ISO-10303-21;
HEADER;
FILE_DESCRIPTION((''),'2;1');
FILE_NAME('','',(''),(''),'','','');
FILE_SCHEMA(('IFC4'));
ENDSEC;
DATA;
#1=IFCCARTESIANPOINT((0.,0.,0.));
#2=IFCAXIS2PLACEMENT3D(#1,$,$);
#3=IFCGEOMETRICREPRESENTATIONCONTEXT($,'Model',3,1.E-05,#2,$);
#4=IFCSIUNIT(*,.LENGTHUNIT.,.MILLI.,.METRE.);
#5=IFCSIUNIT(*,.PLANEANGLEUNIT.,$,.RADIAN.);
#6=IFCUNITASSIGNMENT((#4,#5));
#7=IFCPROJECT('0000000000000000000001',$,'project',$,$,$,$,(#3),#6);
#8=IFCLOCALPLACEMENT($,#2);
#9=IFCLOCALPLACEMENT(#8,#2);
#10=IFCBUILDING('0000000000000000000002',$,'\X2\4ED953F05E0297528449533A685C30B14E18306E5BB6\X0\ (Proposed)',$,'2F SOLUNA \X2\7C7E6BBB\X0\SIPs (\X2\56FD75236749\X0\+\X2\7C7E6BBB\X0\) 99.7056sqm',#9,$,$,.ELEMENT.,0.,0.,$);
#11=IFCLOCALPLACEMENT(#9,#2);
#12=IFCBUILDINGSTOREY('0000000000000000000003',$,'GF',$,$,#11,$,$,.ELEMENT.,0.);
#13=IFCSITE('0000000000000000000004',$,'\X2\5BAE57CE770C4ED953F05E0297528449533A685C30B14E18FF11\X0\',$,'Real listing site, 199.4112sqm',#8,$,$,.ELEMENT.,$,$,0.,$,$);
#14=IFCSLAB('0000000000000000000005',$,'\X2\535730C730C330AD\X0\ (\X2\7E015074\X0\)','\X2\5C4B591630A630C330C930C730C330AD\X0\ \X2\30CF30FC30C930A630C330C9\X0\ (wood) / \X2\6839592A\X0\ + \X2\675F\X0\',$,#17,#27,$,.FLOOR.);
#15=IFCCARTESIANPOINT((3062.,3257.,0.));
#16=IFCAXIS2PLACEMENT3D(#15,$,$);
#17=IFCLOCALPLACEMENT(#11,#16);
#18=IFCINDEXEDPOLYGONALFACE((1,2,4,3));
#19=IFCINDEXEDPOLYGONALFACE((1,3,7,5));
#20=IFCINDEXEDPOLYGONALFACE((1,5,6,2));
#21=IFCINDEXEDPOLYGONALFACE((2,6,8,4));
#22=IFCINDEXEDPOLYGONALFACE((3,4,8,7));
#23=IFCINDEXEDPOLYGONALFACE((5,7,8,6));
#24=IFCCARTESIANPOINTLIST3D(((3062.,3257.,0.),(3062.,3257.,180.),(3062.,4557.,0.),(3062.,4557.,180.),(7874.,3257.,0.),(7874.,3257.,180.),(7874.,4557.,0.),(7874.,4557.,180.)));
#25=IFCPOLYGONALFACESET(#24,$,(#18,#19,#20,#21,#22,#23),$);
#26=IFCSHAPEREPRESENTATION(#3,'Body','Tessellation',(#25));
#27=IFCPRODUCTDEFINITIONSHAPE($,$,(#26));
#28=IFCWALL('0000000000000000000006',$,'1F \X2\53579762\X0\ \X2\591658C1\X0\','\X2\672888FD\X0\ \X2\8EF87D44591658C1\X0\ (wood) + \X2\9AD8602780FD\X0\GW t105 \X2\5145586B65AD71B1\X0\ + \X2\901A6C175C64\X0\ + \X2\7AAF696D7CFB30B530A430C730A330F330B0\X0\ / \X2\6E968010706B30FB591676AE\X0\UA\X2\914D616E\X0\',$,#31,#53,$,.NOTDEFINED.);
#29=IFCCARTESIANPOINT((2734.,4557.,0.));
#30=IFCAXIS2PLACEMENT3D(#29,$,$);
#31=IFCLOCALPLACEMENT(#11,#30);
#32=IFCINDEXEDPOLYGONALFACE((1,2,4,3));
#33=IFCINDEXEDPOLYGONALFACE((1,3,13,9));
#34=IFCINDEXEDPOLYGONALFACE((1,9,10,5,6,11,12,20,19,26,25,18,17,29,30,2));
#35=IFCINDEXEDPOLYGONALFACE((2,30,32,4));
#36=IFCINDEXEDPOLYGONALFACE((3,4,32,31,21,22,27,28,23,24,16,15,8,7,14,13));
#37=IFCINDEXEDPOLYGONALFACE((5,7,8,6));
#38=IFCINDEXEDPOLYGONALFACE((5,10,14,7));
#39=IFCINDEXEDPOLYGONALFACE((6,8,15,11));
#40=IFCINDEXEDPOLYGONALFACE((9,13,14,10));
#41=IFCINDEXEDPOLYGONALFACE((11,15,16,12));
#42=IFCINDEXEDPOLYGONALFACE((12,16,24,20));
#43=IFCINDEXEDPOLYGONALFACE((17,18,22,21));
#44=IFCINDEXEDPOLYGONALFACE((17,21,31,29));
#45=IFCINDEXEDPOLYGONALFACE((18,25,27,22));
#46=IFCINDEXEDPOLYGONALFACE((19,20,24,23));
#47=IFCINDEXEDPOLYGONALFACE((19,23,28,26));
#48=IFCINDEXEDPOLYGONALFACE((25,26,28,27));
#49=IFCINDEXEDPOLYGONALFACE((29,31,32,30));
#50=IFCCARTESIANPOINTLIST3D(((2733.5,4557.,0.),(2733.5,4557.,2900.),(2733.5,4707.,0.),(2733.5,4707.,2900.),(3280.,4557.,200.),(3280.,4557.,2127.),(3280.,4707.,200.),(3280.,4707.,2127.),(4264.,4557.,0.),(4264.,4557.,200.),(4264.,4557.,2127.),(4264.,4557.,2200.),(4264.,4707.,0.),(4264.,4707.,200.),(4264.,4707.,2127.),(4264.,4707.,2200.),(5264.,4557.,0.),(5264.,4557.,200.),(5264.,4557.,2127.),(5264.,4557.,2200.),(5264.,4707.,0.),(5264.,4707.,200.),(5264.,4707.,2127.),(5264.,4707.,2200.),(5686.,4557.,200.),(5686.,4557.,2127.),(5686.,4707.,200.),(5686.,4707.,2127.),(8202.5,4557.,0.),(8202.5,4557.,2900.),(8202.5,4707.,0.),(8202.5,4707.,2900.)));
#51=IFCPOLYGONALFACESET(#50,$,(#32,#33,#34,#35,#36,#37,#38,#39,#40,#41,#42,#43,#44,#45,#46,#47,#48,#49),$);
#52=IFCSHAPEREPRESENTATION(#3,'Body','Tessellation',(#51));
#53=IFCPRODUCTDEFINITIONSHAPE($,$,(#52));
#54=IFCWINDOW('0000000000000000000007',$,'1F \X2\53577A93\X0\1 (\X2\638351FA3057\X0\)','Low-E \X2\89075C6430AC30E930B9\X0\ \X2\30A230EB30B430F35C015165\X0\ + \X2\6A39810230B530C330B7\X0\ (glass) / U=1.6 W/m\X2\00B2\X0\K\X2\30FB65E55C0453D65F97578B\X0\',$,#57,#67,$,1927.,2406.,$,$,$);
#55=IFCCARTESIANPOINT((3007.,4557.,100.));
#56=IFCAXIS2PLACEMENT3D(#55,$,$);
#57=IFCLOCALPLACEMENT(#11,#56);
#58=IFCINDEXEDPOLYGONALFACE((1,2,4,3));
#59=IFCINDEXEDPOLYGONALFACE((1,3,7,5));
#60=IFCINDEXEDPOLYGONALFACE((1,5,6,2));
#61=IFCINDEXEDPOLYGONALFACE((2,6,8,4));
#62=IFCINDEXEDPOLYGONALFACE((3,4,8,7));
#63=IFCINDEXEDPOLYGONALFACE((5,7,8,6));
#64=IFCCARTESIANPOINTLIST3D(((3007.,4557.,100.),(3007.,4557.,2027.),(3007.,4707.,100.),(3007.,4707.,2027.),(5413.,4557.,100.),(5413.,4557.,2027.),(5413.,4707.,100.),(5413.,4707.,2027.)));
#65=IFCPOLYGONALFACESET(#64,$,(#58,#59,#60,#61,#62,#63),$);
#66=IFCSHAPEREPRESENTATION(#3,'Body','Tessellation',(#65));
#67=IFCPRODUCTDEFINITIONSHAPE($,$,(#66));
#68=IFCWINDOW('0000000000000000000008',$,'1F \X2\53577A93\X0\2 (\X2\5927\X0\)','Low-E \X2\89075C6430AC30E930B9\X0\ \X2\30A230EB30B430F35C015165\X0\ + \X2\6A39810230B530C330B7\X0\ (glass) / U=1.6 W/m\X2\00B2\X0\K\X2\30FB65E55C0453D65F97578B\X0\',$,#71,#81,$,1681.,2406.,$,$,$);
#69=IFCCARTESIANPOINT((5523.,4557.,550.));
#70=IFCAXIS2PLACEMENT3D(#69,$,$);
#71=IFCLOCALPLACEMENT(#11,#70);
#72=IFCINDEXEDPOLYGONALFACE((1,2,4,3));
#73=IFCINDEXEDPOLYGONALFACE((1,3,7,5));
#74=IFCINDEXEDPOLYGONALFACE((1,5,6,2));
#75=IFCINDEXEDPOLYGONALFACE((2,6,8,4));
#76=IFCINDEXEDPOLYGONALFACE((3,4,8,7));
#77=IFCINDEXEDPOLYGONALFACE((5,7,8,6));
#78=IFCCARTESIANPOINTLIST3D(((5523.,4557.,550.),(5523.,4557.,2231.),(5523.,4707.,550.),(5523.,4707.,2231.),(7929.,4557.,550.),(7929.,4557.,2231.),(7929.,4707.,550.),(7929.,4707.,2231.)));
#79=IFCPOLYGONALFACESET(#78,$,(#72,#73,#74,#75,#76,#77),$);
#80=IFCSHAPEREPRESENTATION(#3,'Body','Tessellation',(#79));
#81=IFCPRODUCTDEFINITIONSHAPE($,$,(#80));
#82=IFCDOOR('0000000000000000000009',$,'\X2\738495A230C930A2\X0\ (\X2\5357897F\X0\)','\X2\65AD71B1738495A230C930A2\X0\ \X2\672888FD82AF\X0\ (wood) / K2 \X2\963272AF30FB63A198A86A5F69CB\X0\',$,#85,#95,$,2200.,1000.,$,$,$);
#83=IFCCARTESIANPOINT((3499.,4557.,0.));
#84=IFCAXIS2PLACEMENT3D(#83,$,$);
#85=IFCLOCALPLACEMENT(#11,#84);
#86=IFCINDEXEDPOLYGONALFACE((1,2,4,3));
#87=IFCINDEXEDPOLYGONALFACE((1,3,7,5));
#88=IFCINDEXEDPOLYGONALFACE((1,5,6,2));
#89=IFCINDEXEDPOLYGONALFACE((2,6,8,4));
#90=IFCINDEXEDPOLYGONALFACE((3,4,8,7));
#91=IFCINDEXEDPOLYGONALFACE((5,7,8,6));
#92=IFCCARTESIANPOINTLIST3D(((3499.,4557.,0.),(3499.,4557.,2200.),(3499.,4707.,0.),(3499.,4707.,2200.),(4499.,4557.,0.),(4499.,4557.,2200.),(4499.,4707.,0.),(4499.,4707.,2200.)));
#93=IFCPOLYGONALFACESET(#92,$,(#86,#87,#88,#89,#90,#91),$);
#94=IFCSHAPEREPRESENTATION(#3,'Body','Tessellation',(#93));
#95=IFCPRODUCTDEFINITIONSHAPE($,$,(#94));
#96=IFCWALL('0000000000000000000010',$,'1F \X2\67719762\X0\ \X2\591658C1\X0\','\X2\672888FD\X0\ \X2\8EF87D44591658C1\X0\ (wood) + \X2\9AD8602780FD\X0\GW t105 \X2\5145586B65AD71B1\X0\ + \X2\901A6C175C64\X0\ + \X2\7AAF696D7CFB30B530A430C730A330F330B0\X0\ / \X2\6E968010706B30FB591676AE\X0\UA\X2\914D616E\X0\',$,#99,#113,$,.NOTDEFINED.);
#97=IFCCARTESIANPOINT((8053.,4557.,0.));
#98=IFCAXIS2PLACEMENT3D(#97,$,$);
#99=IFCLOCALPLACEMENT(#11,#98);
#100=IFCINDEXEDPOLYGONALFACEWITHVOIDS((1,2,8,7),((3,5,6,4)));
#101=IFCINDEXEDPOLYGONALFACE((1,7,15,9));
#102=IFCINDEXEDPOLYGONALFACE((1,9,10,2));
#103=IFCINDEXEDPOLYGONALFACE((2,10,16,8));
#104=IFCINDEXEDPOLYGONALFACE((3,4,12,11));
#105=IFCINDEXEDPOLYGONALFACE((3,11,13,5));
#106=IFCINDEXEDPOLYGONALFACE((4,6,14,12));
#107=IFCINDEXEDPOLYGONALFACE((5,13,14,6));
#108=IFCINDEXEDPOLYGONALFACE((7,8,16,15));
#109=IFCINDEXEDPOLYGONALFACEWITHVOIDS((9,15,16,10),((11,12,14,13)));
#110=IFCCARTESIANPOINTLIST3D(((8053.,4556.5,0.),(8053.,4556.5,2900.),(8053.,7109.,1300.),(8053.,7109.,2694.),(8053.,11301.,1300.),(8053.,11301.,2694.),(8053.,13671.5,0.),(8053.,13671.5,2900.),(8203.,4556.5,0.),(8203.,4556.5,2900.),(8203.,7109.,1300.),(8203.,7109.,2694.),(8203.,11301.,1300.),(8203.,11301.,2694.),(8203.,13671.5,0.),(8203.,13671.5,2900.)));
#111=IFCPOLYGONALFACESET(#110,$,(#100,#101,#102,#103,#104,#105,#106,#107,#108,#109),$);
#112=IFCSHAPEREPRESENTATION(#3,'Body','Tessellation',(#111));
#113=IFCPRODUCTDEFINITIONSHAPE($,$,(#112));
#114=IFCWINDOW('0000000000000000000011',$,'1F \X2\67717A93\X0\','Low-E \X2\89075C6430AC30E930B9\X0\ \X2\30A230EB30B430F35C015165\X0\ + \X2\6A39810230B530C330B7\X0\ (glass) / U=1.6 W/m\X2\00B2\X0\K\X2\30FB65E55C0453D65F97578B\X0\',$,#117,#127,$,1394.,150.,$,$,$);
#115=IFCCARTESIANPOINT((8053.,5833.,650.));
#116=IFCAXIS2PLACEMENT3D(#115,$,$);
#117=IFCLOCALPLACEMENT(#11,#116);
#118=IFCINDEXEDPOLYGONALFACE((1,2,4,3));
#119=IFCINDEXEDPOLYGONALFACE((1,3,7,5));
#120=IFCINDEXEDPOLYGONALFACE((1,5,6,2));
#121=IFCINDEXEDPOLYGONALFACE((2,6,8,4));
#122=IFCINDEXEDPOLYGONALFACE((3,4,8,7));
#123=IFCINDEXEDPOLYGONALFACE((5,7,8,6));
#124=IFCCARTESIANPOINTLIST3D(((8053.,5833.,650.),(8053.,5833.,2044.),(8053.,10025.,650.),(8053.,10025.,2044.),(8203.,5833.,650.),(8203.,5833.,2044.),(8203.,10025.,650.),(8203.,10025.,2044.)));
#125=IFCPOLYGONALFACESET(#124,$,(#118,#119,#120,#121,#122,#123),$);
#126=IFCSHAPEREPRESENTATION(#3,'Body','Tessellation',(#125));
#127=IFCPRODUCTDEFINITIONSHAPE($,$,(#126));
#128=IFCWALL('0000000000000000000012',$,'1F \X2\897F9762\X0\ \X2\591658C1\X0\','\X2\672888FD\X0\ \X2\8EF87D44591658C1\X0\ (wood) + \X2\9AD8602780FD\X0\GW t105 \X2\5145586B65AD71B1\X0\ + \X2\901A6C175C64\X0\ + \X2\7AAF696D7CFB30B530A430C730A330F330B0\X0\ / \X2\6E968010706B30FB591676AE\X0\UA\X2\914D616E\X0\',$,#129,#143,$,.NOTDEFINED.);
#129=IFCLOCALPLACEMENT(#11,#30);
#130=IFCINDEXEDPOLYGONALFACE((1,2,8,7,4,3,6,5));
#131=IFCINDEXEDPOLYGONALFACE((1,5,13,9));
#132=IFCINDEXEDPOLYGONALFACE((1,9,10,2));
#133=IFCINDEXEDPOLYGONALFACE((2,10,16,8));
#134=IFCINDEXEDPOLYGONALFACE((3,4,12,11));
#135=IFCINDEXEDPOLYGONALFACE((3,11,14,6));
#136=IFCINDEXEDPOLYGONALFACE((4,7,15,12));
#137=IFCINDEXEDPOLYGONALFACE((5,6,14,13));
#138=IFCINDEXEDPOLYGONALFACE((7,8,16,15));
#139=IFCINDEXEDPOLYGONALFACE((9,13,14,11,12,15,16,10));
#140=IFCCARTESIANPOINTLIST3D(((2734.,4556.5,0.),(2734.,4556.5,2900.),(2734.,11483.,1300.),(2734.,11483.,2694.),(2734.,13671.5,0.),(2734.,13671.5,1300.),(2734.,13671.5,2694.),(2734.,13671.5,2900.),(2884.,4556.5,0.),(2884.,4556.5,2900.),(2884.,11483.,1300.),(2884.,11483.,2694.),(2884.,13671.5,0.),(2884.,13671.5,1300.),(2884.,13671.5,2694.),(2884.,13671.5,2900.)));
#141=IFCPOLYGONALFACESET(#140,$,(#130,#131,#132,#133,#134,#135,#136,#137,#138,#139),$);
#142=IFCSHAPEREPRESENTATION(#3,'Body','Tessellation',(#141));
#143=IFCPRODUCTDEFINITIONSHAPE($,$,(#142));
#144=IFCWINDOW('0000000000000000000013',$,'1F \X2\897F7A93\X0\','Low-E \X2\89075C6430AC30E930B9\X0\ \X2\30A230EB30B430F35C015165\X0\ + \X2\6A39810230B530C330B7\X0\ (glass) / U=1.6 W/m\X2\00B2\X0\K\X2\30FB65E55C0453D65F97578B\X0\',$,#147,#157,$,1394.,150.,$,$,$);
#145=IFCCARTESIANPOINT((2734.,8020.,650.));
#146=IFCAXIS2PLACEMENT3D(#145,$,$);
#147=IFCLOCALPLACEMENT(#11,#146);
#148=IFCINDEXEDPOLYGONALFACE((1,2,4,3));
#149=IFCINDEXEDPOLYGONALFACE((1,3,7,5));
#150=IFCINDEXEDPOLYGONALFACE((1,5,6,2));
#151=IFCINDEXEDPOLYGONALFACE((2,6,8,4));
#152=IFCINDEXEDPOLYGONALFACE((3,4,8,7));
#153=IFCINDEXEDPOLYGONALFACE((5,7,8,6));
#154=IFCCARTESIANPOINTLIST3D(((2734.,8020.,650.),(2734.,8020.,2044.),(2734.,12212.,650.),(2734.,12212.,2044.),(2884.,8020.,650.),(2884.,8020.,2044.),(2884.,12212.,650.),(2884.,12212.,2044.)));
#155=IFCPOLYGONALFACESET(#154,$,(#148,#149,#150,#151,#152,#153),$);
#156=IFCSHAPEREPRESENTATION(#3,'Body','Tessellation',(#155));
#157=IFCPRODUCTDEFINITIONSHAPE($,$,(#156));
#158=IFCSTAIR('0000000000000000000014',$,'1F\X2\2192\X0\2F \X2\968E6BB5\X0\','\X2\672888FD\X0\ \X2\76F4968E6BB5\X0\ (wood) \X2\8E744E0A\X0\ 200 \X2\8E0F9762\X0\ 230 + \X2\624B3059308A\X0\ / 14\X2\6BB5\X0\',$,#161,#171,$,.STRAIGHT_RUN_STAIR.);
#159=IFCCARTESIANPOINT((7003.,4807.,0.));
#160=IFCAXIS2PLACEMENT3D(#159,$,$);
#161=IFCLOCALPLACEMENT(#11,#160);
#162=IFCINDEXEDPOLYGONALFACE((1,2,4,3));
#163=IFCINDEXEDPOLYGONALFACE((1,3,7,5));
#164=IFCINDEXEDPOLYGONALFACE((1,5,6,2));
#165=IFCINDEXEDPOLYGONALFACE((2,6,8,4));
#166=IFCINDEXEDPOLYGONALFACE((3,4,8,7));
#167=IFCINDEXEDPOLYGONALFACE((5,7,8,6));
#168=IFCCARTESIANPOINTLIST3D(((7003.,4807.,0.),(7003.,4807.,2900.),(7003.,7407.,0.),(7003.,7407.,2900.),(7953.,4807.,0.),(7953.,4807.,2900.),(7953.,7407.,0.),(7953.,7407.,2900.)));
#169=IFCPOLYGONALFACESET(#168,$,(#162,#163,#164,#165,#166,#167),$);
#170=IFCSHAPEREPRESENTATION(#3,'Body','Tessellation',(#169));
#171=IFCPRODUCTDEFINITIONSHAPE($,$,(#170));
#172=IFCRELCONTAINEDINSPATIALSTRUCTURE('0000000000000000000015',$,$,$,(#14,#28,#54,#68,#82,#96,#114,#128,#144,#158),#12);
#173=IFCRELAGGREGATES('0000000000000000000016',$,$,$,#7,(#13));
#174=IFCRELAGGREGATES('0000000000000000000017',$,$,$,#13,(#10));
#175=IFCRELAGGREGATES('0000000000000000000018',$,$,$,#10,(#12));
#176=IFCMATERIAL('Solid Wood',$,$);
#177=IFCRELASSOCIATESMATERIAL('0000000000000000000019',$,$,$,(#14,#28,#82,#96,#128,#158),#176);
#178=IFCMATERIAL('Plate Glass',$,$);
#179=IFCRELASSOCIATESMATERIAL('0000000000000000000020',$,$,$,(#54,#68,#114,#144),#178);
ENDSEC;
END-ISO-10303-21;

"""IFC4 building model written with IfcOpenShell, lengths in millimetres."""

from ifc_helpers import new_model, si_unit, frame, frame_2d, origin, place, context, project, spatial, rectangle, extrude, material, element, fill, save


model = new_model("IFC4")

# Units and contexts
model_context = context("Model", 3, precision=1e-05, world=origin())
ifc_project = project(units=[si_unit("LENGTHUNIT", "METRE", prefix="MILLI"), si_unit("PLANEANGLEUNIT", "RADIAN")], contexts=[model_context])

# Site, building, storey
site_placement = place(None, origin())
site = spatial("IfcSite", under=ifc_project, at=site_placement, Name="宮城県仙台市青葉区桜ケ丘１", ObjectType="Real listing site, 199.4112sqm", CompositionType="ELEMENT", RefElevation=0.0)
building_placement = place(site_placement, origin())
building = spatial("IfcBuilding", under=site, at=building_placement, Name="仙台市青葉区桜ケ丘の家 (Proposed)", ObjectType="2F SOLUNA 籾殻SIPs (国産杉+籾殻) 99.7056sqm", CompositionType="ELEMENT", ElevationOfRefHeight=0.0, ElevationOfTerrain=0.0)
storey_placement = place(building_placement, origin())
storey = spatial("IfcBuildingStorey", under=building, at=storey_placement, Name="GF", CompositionType="ELEMENT", Elevation=0.0)

# Slab
ifc_material_1 = material(Name="Solid Wood")
slab_1_placement = place(storey_placement, frame((3062.0, 3257.0, 0.0)))
element("IfcSlab", 1, at=slab_1_placement, inside=storey, material=ifc_material_1, Name="南デッキ (縁側)", Description="屋外ウッドデッキ ハードウッド (wood) / 根太 + 束", PredefinedType="FLOOR", context=model_context, shape_type="SweptSolid", body=[
    extrude(rectangle(XDim=4812.0, YDim=1300.0, at=frame_2d((2406.0, 650.0))), frame((3062.0, 3257.0, 0.0)), (0.0, 0.0, 1.0), 180.0),
])

# Wall, openings, windows, door
wall_1_placement = place(storey_placement, frame((2734.0, 4557.0, 0.0)))
wall_1 = element("IfcWall", 2, at=wall_1_placement, inside=storey, material=ifc_material_1, Name="1F 南面 外壁", Description="木製 軸組外壁 (wood) + 高性能GW t105 充填断熱 + 通気層 + 窯業系サイディング / 準耐火・外皮UA配慮", PredefinedType="NOTDEFINED", context=model_context, shape_type="SweptSolid", body=[
    extrude(rectangle(XDim=5469.0, YDim=150.0, at=frame_2d((2734.0, 75.0))), frame((2734.0, 4557.0, 0.0)), (0.0, 0.0, 1.0), 2900.0),
])
opening_1_placement = place(storey_placement, frame((3007.0, 4557.0, 100.0)))
opening_1 = element("IfcOpeningElement", 3, at=opening_1_placement, cuts=wall_1, PredefinedType="NOTDEFINED", context=model_context, shape_type="SweptSolid", body=[
    extrude(rectangle(XDim=2406.0, YDim=150.0, at=frame_2d((1203.0, 75.0))), frame((3007.0, 4557.0, 100.0)), (0.0, 0.0, 1.0), 1927.0),
])
opening_2_placement = place(storey_placement, frame((5523.0, 4557.0, 550.0)))
opening_2 = element("IfcOpeningElement", 4, at=opening_2_placement, cuts=wall_1, PredefinedType="NOTDEFINED", context=model_context, shape_type="SweptSolid", body=[
    extrude(rectangle(XDim=2406.0, YDim=150.0, at=frame_2d((1203.0, 75.0))), frame((5523.0, 4557.0, 550.0)), (0.0, 0.0, 1.0), 1681.0),
])
opening_3_placement = place(storey_placement, frame((3499.0, 4557.0, 0.0)))
opening_3 = element("IfcOpeningElement", 5, at=opening_3_placement, cuts=wall_1, PredefinedType="NOTDEFINED", context=model_context, shape_type="SweptSolid", body=[
    extrude(rectangle(XDim=1000.0, YDim=150.0, at=frame_2d((500.0, 75.0))), frame((3499.0, 4557.0, 0.0)), (0.0, 0.0, 1.0), 2200.0),
])
ifc_material_2 = material(Name="Plate Glass")
window_1_placement = place(storey_placement, frame((3007.0, 4557.0, 100.0)))
window_1 = element("IfcWindow", 6, at=window_1_placement, inside=storey, material=ifc_material_2, Name="1F 南窓1 (掃出し)", Description="Low-E 複層ガラス アルゴン封入 + 樹脂サッシ (glass) / U=1.6 W/m²K・日射取得型", OverallHeight=1927.0, OverallWidth=2406.0, context=model_context, shape_type="SweptSolid", body=[
    extrude(rectangle(XDim=2406.0, YDim=150.0, at=frame_2d((1203.0, 75.0))), frame((3007.0, 4557.0, 100.0)), (0.0, 0.0, 1.0), 1927.0),
])
fill(opening_1, window_1)
window_2_placement = place(storey_placement, frame((5523.0, 4557.0, 550.0)))
window_2 = element("IfcWindow", 7, at=window_2_placement, inside=storey, material=ifc_material_2, Name="1F 南窓2 (大)", Description="Low-E 複層ガラス アルゴン封入 + 樹脂サッシ (glass) / U=1.6 W/m²K・日射取得型", OverallHeight=1681.0, OverallWidth=2406.0, context=model_context, shape_type="SweptSolid", body=[
    extrude(rectangle(XDim=2406.0, YDim=150.0, at=frame_2d((1203.0, 75.0))), frame((5523.0, 4557.0, 550.0)), (0.0, 0.0, 1.0), 1681.0),
])
fill(opening_2, window_2)
door_placement = place(storey_placement, frame((3499.0, 4557.0, 0.0)))
door = element("IfcDoor", 8, at=door_placement, inside=storey, material=ifc_material_1, Name="玄関ドア (南西)", Description="断熱玄関ドア 木製芯 (wood) / K2 防犯・採風機構", OverallHeight=2200.0, OverallWidth=1000.0, context=model_context, shape_type="SweptSolid", body=[
    extrude(rectangle(XDim=1000.0, YDim=150.0, at=frame_2d((500.0, 75.0))), frame((3499.0, 4557.0, 0.0)), (0.0, 0.0, 1.0), 2200.0),
])
fill(opening_3, door)

# Walls, openings, windows
wall_2_placement = place(storey_placement, frame((8053.0, 4557.0, 0.0)))
wall_2 = element("IfcWall", 9, at=wall_2_placement, inside=storey, material=ifc_material_1, Name="1F 東面 外壁", Description="木製 軸組外壁 (wood) + 高性能GW t105 充填断熱 + 通気層 + 窯業系サイディング / 準耐火・外皮UA配慮", PredefinedType="NOTDEFINED", context=model_context, shape_type="SweptSolid", body=[
    extrude(rectangle(XDim=150.0, YDim=9115.0, at=frame_2d((75.0, 4557.0))), frame((8053.0, 4557.0, 0.0)), (0.0, 0.0, 1.0), 2900.0),
])
opening_4_placement = place(storey_placement, frame((8053.0, 5833.0, 650.0)))
opening_4 = element("IfcOpeningElement", 10, at=opening_4_placement, cuts=wall_2, PredefinedType="NOTDEFINED", context=model_context, shape_type="SweptSolid", body=[
    extrude(rectangle(XDim=150.0, YDim=4192.0, at=frame_2d((75.0, 2096.0))), frame((8053.0, 5833.0, 650.0)), (0.0, 0.0, 1.0), 1394.0),
])
window_3_placement = place(storey_placement, frame((8053.0, 5833.0, 650.0)))
window_3 = element("IfcWindow", 11, at=window_3_placement, inside=storey, material=ifc_material_2, Name="1F 東窓", Description="Low-E 複層ガラス アルゴン封入 + 樹脂サッシ (glass) / U=1.6 W/m²K・日射取得型", OverallHeight=1394.0, OverallWidth=150.0, context=model_context, shape_type="SweptSolid", body=[
    extrude(rectangle(XDim=150.0, YDim=4192.0, at=frame_2d((75.0, 2096.0))), frame((8053.0, 5833.0, 650.0)), (0.0, 0.0, 1.0), 1394.0),
])
fill(opening_4, window_3)
wall_3_placement = place(storey_placement, frame((2734.0, 4557.0, 0.0)))
wall_3 = element("IfcWall", 12, at=wall_3_placement, inside=storey, material=ifc_material_1, Name="1F 西面 外壁", Description="木製 軸組外壁 (wood) + 高性能GW t105 充填断熱 + 通気層 + 窯業系サイディング / 準耐火・外皮UA配慮", PredefinedType="NOTDEFINED", context=model_context, shape_type="SweptSolid", body=[
    extrude(rectangle(XDim=150.0, YDim=9115.0, at=frame_2d((75.0, 4557.0))), frame((2734.0, 4557.0, 0.0)), (0.0, 0.0, 1.0), 2900.0),
])
opening_5_placement = place(storey_placement, frame((2734.0, 8020.0, 650.0)))
opening_5 = element("IfcOpeningElement", 13, at=opening_5_placement, cuts=wall_3, PredefinedType="NOTDEFINED", context=model_context, shape_type="SweptSolid", body=[
    extrude(rectangle(XDim=150.0, YDim=4192.0, at=frame_2d((75.0, 2096.0))), frame((2734.0, 8020.0, 650.0)), (0.0, 0.0, 1.0), 1394.0),
])
window_4_placement = place(storey_placement, frame((2734.0, 8020.0, 650.0)))
window_4 = element("IfcWindow", 14, at=window_4_placement, inside=storey, material=ifc_material_2, Name="1F 西窓", Description="Low-E 複層ガラス アルゴン封入 + 樹脂サッシ (glass) / U=1.6 W/m²K・日射取得型", OverallHeight=1394.0, OverallWidth=150.0, context=model_context, shape_type="SweptSolid", body=[
    extrude(rectangle(XDim=150.0, YDim=4192.0, at=frame_2d((75.0, 2096.0))), frame((2734.0, 8020.0, 650.0)), (0.0, 0.0, 1.0), 1394.0),
])
fill(opening_5, window_4)

# Stair
stair_placement = place(storey_placement, frame((7003.0, 4807.0, 0.0)))
element("IfcStair", 15, at=stair_placement, inside=storey, material=ifc_material_1, Name="1F→2F 階段", Description="木製 直階段 (wood) 蹴上 200 踏面 230 + 手すり / 14段", PredefinedType="STRAIGHT_RUN_STAIR", context=model_context, shape_type="SweptSolid", body=[
    extrude(rectangle(XDim=950.0, YDim=2600.0, at=frame_2d((475.0, 1300.0))), frame((7003.0, 4807.0, 0.0)), (0.0, 0.0, 1.0), 2900.0),
])

save(model, "model.ifc")
